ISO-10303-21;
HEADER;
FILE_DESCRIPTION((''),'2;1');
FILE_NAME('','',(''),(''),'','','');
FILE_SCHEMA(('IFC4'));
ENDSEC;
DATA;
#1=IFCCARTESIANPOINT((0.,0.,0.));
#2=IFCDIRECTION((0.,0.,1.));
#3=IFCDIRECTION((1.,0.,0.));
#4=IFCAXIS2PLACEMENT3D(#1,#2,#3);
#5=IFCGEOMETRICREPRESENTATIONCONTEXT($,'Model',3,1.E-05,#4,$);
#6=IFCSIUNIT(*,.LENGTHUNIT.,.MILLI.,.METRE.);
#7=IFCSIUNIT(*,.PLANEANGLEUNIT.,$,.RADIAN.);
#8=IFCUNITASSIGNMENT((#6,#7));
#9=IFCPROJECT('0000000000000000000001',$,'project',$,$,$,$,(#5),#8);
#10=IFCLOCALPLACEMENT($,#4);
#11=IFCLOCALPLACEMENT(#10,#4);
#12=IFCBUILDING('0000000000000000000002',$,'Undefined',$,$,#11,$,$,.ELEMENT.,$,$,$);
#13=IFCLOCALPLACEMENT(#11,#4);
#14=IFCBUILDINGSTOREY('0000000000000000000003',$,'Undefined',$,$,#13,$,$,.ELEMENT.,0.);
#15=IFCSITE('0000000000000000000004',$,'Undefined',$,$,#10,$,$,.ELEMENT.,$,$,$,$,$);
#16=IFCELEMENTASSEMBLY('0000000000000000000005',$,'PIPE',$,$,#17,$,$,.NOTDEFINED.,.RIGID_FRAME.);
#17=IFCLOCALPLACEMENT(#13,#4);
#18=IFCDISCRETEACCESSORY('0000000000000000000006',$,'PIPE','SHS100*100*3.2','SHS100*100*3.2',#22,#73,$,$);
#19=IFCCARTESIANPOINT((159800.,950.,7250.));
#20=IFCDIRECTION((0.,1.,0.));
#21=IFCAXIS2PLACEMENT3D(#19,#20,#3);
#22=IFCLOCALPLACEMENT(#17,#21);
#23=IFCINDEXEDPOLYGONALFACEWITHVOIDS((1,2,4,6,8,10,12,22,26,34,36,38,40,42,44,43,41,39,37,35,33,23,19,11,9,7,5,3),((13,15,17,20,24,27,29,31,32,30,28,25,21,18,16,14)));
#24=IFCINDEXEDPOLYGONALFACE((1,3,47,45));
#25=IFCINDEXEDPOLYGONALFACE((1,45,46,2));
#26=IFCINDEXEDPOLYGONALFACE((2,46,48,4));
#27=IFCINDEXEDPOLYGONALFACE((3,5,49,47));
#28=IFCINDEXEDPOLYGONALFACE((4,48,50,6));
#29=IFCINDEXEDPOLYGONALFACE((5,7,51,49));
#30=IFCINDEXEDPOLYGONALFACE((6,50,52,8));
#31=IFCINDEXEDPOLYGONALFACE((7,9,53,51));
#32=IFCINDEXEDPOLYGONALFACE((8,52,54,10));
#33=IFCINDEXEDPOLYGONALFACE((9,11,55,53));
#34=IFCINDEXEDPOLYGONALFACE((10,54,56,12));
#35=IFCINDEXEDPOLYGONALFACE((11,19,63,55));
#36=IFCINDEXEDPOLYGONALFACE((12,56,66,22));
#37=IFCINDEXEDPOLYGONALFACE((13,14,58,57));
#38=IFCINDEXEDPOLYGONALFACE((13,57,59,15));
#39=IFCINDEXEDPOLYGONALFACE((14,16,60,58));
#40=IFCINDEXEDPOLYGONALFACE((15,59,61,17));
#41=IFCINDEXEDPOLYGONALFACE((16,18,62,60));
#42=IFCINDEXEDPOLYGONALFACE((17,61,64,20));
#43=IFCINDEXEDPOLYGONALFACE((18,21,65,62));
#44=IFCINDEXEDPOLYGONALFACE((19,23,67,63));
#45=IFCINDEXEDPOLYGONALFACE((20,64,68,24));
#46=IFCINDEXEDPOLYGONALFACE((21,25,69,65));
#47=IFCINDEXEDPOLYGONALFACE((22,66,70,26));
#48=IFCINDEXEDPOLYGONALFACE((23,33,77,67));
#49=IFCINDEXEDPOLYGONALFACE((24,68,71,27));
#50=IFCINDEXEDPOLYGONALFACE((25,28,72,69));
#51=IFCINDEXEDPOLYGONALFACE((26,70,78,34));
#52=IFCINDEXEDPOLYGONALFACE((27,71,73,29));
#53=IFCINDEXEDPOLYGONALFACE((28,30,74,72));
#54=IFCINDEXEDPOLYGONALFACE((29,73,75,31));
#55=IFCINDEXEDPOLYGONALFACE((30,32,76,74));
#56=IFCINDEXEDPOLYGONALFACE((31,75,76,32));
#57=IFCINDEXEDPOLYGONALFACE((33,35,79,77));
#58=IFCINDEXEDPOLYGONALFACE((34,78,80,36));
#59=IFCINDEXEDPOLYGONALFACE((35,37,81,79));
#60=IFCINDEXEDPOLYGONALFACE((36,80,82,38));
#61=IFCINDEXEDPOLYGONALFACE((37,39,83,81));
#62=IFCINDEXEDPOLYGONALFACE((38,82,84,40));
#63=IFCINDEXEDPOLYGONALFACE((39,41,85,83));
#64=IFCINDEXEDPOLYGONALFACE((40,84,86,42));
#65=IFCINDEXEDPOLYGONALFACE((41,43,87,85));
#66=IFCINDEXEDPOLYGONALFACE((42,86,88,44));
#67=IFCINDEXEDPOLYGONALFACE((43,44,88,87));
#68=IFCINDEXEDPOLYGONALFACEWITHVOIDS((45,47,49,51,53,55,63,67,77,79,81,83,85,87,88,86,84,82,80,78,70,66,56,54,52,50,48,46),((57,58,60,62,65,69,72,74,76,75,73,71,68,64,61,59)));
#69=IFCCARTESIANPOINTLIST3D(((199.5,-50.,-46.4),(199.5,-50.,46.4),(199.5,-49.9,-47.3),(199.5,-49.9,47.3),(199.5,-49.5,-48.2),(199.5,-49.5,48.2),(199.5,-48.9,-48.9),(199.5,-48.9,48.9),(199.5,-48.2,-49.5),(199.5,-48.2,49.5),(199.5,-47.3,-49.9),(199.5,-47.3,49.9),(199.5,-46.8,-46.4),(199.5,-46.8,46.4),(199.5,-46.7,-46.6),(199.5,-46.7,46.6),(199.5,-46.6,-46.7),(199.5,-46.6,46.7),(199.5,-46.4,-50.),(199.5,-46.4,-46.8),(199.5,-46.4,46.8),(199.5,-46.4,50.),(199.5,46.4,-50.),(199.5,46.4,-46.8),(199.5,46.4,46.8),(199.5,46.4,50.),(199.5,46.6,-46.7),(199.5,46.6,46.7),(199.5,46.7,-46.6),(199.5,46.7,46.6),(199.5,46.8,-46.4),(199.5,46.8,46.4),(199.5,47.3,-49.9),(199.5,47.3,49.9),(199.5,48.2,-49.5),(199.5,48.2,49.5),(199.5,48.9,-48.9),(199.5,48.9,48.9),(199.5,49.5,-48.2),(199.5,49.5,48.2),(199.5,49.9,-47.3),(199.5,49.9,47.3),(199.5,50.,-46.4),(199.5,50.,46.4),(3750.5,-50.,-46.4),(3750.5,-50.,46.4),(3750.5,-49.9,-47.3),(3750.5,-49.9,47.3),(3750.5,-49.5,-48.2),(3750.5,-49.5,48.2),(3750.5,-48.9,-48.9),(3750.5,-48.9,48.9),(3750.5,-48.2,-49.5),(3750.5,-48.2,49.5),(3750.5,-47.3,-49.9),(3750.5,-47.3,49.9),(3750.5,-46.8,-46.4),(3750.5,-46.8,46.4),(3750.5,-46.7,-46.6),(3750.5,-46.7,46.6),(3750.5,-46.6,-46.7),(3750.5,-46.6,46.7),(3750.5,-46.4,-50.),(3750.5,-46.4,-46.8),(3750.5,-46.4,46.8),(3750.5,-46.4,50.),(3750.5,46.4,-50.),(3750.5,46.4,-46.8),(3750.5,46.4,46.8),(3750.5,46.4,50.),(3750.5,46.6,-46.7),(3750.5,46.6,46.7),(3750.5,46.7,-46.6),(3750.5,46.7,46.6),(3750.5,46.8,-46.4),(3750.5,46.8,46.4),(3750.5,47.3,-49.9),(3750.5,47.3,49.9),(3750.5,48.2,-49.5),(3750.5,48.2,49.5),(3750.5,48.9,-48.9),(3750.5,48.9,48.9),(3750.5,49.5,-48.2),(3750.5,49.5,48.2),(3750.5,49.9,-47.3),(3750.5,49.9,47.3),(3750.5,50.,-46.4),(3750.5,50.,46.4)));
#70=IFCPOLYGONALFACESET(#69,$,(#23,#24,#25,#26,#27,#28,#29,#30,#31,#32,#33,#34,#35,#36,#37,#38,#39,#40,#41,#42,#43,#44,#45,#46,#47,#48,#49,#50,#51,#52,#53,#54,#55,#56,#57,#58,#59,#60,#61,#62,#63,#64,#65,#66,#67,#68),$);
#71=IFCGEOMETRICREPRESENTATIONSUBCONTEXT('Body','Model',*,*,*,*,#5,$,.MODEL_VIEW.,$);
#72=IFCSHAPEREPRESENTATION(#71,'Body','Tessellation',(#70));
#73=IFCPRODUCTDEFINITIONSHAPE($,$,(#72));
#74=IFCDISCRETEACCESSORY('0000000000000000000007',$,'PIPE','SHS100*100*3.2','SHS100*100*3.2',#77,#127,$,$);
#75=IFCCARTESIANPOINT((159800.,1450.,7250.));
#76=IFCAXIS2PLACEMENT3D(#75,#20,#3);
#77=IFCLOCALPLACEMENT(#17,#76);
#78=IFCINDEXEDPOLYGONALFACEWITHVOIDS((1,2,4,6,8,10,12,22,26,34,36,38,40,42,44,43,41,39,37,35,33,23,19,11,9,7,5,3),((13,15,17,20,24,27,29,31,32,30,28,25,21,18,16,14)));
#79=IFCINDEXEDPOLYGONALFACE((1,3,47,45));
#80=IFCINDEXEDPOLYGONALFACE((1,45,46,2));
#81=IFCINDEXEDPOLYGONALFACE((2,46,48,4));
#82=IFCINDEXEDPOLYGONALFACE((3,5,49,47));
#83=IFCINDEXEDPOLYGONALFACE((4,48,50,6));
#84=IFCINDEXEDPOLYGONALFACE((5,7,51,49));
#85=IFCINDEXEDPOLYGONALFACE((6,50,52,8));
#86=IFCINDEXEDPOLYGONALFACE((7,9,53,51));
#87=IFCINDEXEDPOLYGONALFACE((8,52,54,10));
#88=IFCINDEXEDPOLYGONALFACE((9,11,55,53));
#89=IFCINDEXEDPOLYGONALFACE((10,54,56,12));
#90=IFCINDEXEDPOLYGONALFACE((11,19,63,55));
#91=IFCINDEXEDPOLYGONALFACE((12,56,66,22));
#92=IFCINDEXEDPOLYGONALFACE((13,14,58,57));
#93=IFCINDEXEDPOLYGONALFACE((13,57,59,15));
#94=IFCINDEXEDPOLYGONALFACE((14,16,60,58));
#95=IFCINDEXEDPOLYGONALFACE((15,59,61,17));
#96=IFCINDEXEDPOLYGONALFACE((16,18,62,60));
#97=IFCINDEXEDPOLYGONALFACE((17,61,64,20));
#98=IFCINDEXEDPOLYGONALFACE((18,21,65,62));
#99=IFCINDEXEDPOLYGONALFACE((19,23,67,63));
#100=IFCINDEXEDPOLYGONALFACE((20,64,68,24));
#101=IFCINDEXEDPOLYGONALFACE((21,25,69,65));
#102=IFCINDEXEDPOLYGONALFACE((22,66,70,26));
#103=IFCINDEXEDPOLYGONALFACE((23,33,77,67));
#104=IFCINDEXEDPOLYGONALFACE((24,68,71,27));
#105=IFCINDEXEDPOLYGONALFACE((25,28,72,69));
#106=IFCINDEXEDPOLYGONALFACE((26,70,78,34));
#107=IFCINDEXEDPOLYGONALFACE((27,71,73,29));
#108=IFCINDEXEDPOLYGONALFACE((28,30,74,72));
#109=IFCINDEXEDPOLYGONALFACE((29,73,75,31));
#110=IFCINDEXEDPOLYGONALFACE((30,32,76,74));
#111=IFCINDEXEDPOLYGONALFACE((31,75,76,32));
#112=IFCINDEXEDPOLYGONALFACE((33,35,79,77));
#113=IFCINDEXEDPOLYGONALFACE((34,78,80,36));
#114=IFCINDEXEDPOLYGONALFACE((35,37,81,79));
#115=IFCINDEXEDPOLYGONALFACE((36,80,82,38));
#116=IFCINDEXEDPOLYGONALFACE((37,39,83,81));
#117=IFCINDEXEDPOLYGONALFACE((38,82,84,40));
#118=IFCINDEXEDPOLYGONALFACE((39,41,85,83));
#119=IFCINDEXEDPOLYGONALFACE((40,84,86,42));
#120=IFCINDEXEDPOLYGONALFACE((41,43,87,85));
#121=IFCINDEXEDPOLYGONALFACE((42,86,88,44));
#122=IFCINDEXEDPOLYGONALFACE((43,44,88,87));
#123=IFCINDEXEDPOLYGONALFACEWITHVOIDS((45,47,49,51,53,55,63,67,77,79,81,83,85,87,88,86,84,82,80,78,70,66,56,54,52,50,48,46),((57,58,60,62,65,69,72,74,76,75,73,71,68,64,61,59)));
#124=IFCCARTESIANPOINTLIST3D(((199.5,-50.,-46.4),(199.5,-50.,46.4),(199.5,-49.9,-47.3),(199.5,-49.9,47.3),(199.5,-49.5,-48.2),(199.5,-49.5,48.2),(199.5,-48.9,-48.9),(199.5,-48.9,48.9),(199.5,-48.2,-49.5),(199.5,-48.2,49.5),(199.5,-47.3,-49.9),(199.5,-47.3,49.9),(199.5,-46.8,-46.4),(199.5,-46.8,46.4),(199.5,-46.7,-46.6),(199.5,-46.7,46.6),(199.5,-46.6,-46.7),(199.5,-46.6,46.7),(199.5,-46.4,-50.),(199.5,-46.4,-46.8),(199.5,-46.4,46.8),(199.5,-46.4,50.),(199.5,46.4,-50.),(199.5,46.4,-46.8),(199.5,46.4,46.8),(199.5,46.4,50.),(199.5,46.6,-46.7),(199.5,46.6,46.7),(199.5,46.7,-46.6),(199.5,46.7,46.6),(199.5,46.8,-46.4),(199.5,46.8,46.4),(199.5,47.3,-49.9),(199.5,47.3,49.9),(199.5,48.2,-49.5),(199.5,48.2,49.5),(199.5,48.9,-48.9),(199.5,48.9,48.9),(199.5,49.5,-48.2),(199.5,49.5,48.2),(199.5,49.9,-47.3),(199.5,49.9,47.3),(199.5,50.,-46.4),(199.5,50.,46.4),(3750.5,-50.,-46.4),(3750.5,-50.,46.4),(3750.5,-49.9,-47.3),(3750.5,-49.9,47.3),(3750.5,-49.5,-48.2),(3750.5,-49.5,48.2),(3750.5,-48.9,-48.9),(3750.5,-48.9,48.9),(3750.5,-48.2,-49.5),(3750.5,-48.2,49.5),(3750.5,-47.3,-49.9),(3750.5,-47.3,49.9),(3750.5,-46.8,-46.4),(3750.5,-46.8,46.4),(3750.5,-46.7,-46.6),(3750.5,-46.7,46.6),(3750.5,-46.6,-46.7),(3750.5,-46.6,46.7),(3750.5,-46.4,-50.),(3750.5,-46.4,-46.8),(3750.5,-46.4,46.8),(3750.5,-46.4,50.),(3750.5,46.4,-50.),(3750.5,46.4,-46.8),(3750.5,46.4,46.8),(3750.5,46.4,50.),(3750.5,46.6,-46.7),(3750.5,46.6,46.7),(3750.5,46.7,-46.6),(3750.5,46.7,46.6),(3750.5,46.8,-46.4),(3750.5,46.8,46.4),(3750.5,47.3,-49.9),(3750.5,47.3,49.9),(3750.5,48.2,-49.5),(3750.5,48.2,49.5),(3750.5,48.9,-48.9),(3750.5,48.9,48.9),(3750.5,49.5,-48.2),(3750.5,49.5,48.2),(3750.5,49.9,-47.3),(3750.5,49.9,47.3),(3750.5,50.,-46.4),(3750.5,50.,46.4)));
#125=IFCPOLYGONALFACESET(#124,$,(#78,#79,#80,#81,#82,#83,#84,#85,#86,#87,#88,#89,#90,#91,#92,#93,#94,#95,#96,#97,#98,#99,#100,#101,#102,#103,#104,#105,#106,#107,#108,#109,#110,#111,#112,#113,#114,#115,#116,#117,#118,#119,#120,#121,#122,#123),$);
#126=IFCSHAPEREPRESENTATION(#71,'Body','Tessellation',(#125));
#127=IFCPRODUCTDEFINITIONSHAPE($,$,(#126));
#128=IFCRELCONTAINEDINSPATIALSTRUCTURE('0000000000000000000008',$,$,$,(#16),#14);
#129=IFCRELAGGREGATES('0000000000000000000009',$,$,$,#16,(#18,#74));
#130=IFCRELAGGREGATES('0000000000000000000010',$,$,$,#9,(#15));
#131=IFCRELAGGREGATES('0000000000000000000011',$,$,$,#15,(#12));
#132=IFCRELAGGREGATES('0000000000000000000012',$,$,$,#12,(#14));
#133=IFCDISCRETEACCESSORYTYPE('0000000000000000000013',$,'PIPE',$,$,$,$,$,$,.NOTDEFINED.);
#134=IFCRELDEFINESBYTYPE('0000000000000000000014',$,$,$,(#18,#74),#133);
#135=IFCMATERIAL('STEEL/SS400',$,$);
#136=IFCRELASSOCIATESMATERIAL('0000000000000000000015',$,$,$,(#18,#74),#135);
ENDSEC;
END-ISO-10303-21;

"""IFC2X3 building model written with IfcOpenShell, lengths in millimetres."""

from ifc_helpers import new_model, si_unit, frame, origin_with_axes, origin_2d_with_axis, place, context, subcontext, project, spatial, hollow_rectangle, extrude, clip, halfspace, material, type_object, element, aggregate, save


model = new_model("IFC2X3")

# Units and contexts
model_context = context("Model", 3, precision=1e-05, world=origin_with_axes())
body_context = subcontext(model_context, "Body", "Model", "MODEL_VIEW")
ifc_project = project(units=[si_unit("LENGTHUNIT", "METRE", prefix="MILLI"), si_unit("PLANEANGLEUNIT", "RADIAN")], contexts=[model_context])

# Site, building, storey
site_placement = place(None, origin_with_axes())
site = spatial("IfcSite", under=ifc_project, at=site_placement, Name="Undefined", CompositionType="ELEMENT")
building_placement = place(site_placement, origin_with_axes())
building = spatial("IfcBuilding", under=site, at=building_placement, Name="Undefined", CompositionType="ELEMENT")
storey_placement = place(building_placement, origin_with_axes())
storey = spatial("IfcBuildingStorey", under=building, at=storey_placement, Name="Undefined", CompositionType="ELEMENT", Elevation=0.0)

# Element assembly
assembly_1_placement = place(storey_placement, origin_with_axes())
assembly_1 = element("IfcElementAssembly", 1, at=assembly_1_placement, inside=storey, Name="PIPE", AssemblyPlace="NOTDEFINED", PredefinedType="RIGID_FRAME")
ifc_material_1 = material(Name="STEEL/SS400")
discrete_accessory_type_1 = type_object("IfcDiscreteAccessoryType", Name="PIPE")

# Discrete accessories
discrete_accessory_1_placement = place(assembly_1_placement, frame((159800.0, 950.0, 7250.0), z_axis=(0.0, 1.0, 0.0), x_axis=(1.0, 0.0, 0.0)))
discrete_accessory_1 = element("IfcDiscreteAccessory", 2, at=discrete_accessory_1_placement, type_object=discrete_accessory_type_1, material=ifc_material_1, Name="PIPE", Description="SHS100*100*3.2", ObjectType="SHS100*100*3.2", context=body_context, shape_type="Clipping", body=[
    clip(clip(clip(clip(extrude(hollow_rectangle(XDim=100.0, YDim=100.0, WallThickness=3.2, InnerFilletRadius=0.4, OuterFilletRadius=3.6, at=origin_2d_with_axis()), frame((3750.5, 0.0, 0.0), z_axis=(-1.0, 0.0, 0.0), x_axis=(0.0, -1.0, 0.0)), (0.0, 0.0, 1.0), 3551.0), halfspace(frame((3750.5, -50.0, -50.0), z_axis=(1.0, 0.0, 0.0), x_axis=(0.0, 0.0, 1.0)), False)), halfspace(frame((199.5, -50.0, -50.0), z_axis=(-1.0, 0.0, 0.0), x_axis=(0.0, 1.0, 0.0)), False)), halfspace(frame((3750.5, 0.0, -50.0), z_axis=(-1.0, 0.0, 0.0), x_axis=(0.0, 1.0, 0.0)), True)), halfspace(frame((199.5, 0.0, -50.0), z_axis=(1.0, 0.0, 0.0), x_axis=(0.0, 0.0, 1.0)), True)),
])
discrete_accessory_2_placement = place(assembly_1_placement, frame((159800.0, 1450.0, 7250.0), z_axis=(0.0, 1.0, 0.0), x_axis=(1.0, 0.0, 0.0)))
discrete_accessory_2 = element("IfcDiscreteAccessory", 3, at=discrete_accessory_2_placement, type_object=discrete_accessory_type_1, material=ifc_material_1, Name="PIPE", Description="SHS100*100*3.2", ObjectType="SHS100*100*3.2", context=body_context, shape_type="Clipping", body=[
    clip(clip(clip(clip(extrude(hollow_rectangle(XDim=100.0, YDim=100.0, WallThickness=3.2, InnerFilletRadius=0.4, OuterFilletRadius=3.6, at=origin_2d_with_axis()), frame((3750.5, 0.0, 0.0), z_axis=(-1.0, 0.0, 0.0), x_axis=(0.0, -1.0, 0.0)), (0.0, 0.0, 1.0), 3551.0), halfspace(frame((3750.5, -50.0, -50.0), z_axis=(1.0, 0.0, 0.0), x_axis=(0.0, 0.0, 1.0)), False)), halfspace(frame((199.5, -50.0, -50.0), z_axis=(-1.0, 0.0, 0.0), x_axis=(0.0, 1.0, 0.0)), False)), halfspace(frame((3750.5, 0.0, -50.0), z_axis=(-1.0, 0.0, 0.0), x_axis=(0.0, 1.0, 0.0)), True)), halfspace(frame((199.5, 0.0, -50.0), z_axis=(1.0, 0.0, 0.0), x_axis=(0.0, 0.0, 1.0)), True)),
])
aggregate(assembly_1, [discrete_accessory_1, discrete_accessory_2])

save(model, "model.ifc")
